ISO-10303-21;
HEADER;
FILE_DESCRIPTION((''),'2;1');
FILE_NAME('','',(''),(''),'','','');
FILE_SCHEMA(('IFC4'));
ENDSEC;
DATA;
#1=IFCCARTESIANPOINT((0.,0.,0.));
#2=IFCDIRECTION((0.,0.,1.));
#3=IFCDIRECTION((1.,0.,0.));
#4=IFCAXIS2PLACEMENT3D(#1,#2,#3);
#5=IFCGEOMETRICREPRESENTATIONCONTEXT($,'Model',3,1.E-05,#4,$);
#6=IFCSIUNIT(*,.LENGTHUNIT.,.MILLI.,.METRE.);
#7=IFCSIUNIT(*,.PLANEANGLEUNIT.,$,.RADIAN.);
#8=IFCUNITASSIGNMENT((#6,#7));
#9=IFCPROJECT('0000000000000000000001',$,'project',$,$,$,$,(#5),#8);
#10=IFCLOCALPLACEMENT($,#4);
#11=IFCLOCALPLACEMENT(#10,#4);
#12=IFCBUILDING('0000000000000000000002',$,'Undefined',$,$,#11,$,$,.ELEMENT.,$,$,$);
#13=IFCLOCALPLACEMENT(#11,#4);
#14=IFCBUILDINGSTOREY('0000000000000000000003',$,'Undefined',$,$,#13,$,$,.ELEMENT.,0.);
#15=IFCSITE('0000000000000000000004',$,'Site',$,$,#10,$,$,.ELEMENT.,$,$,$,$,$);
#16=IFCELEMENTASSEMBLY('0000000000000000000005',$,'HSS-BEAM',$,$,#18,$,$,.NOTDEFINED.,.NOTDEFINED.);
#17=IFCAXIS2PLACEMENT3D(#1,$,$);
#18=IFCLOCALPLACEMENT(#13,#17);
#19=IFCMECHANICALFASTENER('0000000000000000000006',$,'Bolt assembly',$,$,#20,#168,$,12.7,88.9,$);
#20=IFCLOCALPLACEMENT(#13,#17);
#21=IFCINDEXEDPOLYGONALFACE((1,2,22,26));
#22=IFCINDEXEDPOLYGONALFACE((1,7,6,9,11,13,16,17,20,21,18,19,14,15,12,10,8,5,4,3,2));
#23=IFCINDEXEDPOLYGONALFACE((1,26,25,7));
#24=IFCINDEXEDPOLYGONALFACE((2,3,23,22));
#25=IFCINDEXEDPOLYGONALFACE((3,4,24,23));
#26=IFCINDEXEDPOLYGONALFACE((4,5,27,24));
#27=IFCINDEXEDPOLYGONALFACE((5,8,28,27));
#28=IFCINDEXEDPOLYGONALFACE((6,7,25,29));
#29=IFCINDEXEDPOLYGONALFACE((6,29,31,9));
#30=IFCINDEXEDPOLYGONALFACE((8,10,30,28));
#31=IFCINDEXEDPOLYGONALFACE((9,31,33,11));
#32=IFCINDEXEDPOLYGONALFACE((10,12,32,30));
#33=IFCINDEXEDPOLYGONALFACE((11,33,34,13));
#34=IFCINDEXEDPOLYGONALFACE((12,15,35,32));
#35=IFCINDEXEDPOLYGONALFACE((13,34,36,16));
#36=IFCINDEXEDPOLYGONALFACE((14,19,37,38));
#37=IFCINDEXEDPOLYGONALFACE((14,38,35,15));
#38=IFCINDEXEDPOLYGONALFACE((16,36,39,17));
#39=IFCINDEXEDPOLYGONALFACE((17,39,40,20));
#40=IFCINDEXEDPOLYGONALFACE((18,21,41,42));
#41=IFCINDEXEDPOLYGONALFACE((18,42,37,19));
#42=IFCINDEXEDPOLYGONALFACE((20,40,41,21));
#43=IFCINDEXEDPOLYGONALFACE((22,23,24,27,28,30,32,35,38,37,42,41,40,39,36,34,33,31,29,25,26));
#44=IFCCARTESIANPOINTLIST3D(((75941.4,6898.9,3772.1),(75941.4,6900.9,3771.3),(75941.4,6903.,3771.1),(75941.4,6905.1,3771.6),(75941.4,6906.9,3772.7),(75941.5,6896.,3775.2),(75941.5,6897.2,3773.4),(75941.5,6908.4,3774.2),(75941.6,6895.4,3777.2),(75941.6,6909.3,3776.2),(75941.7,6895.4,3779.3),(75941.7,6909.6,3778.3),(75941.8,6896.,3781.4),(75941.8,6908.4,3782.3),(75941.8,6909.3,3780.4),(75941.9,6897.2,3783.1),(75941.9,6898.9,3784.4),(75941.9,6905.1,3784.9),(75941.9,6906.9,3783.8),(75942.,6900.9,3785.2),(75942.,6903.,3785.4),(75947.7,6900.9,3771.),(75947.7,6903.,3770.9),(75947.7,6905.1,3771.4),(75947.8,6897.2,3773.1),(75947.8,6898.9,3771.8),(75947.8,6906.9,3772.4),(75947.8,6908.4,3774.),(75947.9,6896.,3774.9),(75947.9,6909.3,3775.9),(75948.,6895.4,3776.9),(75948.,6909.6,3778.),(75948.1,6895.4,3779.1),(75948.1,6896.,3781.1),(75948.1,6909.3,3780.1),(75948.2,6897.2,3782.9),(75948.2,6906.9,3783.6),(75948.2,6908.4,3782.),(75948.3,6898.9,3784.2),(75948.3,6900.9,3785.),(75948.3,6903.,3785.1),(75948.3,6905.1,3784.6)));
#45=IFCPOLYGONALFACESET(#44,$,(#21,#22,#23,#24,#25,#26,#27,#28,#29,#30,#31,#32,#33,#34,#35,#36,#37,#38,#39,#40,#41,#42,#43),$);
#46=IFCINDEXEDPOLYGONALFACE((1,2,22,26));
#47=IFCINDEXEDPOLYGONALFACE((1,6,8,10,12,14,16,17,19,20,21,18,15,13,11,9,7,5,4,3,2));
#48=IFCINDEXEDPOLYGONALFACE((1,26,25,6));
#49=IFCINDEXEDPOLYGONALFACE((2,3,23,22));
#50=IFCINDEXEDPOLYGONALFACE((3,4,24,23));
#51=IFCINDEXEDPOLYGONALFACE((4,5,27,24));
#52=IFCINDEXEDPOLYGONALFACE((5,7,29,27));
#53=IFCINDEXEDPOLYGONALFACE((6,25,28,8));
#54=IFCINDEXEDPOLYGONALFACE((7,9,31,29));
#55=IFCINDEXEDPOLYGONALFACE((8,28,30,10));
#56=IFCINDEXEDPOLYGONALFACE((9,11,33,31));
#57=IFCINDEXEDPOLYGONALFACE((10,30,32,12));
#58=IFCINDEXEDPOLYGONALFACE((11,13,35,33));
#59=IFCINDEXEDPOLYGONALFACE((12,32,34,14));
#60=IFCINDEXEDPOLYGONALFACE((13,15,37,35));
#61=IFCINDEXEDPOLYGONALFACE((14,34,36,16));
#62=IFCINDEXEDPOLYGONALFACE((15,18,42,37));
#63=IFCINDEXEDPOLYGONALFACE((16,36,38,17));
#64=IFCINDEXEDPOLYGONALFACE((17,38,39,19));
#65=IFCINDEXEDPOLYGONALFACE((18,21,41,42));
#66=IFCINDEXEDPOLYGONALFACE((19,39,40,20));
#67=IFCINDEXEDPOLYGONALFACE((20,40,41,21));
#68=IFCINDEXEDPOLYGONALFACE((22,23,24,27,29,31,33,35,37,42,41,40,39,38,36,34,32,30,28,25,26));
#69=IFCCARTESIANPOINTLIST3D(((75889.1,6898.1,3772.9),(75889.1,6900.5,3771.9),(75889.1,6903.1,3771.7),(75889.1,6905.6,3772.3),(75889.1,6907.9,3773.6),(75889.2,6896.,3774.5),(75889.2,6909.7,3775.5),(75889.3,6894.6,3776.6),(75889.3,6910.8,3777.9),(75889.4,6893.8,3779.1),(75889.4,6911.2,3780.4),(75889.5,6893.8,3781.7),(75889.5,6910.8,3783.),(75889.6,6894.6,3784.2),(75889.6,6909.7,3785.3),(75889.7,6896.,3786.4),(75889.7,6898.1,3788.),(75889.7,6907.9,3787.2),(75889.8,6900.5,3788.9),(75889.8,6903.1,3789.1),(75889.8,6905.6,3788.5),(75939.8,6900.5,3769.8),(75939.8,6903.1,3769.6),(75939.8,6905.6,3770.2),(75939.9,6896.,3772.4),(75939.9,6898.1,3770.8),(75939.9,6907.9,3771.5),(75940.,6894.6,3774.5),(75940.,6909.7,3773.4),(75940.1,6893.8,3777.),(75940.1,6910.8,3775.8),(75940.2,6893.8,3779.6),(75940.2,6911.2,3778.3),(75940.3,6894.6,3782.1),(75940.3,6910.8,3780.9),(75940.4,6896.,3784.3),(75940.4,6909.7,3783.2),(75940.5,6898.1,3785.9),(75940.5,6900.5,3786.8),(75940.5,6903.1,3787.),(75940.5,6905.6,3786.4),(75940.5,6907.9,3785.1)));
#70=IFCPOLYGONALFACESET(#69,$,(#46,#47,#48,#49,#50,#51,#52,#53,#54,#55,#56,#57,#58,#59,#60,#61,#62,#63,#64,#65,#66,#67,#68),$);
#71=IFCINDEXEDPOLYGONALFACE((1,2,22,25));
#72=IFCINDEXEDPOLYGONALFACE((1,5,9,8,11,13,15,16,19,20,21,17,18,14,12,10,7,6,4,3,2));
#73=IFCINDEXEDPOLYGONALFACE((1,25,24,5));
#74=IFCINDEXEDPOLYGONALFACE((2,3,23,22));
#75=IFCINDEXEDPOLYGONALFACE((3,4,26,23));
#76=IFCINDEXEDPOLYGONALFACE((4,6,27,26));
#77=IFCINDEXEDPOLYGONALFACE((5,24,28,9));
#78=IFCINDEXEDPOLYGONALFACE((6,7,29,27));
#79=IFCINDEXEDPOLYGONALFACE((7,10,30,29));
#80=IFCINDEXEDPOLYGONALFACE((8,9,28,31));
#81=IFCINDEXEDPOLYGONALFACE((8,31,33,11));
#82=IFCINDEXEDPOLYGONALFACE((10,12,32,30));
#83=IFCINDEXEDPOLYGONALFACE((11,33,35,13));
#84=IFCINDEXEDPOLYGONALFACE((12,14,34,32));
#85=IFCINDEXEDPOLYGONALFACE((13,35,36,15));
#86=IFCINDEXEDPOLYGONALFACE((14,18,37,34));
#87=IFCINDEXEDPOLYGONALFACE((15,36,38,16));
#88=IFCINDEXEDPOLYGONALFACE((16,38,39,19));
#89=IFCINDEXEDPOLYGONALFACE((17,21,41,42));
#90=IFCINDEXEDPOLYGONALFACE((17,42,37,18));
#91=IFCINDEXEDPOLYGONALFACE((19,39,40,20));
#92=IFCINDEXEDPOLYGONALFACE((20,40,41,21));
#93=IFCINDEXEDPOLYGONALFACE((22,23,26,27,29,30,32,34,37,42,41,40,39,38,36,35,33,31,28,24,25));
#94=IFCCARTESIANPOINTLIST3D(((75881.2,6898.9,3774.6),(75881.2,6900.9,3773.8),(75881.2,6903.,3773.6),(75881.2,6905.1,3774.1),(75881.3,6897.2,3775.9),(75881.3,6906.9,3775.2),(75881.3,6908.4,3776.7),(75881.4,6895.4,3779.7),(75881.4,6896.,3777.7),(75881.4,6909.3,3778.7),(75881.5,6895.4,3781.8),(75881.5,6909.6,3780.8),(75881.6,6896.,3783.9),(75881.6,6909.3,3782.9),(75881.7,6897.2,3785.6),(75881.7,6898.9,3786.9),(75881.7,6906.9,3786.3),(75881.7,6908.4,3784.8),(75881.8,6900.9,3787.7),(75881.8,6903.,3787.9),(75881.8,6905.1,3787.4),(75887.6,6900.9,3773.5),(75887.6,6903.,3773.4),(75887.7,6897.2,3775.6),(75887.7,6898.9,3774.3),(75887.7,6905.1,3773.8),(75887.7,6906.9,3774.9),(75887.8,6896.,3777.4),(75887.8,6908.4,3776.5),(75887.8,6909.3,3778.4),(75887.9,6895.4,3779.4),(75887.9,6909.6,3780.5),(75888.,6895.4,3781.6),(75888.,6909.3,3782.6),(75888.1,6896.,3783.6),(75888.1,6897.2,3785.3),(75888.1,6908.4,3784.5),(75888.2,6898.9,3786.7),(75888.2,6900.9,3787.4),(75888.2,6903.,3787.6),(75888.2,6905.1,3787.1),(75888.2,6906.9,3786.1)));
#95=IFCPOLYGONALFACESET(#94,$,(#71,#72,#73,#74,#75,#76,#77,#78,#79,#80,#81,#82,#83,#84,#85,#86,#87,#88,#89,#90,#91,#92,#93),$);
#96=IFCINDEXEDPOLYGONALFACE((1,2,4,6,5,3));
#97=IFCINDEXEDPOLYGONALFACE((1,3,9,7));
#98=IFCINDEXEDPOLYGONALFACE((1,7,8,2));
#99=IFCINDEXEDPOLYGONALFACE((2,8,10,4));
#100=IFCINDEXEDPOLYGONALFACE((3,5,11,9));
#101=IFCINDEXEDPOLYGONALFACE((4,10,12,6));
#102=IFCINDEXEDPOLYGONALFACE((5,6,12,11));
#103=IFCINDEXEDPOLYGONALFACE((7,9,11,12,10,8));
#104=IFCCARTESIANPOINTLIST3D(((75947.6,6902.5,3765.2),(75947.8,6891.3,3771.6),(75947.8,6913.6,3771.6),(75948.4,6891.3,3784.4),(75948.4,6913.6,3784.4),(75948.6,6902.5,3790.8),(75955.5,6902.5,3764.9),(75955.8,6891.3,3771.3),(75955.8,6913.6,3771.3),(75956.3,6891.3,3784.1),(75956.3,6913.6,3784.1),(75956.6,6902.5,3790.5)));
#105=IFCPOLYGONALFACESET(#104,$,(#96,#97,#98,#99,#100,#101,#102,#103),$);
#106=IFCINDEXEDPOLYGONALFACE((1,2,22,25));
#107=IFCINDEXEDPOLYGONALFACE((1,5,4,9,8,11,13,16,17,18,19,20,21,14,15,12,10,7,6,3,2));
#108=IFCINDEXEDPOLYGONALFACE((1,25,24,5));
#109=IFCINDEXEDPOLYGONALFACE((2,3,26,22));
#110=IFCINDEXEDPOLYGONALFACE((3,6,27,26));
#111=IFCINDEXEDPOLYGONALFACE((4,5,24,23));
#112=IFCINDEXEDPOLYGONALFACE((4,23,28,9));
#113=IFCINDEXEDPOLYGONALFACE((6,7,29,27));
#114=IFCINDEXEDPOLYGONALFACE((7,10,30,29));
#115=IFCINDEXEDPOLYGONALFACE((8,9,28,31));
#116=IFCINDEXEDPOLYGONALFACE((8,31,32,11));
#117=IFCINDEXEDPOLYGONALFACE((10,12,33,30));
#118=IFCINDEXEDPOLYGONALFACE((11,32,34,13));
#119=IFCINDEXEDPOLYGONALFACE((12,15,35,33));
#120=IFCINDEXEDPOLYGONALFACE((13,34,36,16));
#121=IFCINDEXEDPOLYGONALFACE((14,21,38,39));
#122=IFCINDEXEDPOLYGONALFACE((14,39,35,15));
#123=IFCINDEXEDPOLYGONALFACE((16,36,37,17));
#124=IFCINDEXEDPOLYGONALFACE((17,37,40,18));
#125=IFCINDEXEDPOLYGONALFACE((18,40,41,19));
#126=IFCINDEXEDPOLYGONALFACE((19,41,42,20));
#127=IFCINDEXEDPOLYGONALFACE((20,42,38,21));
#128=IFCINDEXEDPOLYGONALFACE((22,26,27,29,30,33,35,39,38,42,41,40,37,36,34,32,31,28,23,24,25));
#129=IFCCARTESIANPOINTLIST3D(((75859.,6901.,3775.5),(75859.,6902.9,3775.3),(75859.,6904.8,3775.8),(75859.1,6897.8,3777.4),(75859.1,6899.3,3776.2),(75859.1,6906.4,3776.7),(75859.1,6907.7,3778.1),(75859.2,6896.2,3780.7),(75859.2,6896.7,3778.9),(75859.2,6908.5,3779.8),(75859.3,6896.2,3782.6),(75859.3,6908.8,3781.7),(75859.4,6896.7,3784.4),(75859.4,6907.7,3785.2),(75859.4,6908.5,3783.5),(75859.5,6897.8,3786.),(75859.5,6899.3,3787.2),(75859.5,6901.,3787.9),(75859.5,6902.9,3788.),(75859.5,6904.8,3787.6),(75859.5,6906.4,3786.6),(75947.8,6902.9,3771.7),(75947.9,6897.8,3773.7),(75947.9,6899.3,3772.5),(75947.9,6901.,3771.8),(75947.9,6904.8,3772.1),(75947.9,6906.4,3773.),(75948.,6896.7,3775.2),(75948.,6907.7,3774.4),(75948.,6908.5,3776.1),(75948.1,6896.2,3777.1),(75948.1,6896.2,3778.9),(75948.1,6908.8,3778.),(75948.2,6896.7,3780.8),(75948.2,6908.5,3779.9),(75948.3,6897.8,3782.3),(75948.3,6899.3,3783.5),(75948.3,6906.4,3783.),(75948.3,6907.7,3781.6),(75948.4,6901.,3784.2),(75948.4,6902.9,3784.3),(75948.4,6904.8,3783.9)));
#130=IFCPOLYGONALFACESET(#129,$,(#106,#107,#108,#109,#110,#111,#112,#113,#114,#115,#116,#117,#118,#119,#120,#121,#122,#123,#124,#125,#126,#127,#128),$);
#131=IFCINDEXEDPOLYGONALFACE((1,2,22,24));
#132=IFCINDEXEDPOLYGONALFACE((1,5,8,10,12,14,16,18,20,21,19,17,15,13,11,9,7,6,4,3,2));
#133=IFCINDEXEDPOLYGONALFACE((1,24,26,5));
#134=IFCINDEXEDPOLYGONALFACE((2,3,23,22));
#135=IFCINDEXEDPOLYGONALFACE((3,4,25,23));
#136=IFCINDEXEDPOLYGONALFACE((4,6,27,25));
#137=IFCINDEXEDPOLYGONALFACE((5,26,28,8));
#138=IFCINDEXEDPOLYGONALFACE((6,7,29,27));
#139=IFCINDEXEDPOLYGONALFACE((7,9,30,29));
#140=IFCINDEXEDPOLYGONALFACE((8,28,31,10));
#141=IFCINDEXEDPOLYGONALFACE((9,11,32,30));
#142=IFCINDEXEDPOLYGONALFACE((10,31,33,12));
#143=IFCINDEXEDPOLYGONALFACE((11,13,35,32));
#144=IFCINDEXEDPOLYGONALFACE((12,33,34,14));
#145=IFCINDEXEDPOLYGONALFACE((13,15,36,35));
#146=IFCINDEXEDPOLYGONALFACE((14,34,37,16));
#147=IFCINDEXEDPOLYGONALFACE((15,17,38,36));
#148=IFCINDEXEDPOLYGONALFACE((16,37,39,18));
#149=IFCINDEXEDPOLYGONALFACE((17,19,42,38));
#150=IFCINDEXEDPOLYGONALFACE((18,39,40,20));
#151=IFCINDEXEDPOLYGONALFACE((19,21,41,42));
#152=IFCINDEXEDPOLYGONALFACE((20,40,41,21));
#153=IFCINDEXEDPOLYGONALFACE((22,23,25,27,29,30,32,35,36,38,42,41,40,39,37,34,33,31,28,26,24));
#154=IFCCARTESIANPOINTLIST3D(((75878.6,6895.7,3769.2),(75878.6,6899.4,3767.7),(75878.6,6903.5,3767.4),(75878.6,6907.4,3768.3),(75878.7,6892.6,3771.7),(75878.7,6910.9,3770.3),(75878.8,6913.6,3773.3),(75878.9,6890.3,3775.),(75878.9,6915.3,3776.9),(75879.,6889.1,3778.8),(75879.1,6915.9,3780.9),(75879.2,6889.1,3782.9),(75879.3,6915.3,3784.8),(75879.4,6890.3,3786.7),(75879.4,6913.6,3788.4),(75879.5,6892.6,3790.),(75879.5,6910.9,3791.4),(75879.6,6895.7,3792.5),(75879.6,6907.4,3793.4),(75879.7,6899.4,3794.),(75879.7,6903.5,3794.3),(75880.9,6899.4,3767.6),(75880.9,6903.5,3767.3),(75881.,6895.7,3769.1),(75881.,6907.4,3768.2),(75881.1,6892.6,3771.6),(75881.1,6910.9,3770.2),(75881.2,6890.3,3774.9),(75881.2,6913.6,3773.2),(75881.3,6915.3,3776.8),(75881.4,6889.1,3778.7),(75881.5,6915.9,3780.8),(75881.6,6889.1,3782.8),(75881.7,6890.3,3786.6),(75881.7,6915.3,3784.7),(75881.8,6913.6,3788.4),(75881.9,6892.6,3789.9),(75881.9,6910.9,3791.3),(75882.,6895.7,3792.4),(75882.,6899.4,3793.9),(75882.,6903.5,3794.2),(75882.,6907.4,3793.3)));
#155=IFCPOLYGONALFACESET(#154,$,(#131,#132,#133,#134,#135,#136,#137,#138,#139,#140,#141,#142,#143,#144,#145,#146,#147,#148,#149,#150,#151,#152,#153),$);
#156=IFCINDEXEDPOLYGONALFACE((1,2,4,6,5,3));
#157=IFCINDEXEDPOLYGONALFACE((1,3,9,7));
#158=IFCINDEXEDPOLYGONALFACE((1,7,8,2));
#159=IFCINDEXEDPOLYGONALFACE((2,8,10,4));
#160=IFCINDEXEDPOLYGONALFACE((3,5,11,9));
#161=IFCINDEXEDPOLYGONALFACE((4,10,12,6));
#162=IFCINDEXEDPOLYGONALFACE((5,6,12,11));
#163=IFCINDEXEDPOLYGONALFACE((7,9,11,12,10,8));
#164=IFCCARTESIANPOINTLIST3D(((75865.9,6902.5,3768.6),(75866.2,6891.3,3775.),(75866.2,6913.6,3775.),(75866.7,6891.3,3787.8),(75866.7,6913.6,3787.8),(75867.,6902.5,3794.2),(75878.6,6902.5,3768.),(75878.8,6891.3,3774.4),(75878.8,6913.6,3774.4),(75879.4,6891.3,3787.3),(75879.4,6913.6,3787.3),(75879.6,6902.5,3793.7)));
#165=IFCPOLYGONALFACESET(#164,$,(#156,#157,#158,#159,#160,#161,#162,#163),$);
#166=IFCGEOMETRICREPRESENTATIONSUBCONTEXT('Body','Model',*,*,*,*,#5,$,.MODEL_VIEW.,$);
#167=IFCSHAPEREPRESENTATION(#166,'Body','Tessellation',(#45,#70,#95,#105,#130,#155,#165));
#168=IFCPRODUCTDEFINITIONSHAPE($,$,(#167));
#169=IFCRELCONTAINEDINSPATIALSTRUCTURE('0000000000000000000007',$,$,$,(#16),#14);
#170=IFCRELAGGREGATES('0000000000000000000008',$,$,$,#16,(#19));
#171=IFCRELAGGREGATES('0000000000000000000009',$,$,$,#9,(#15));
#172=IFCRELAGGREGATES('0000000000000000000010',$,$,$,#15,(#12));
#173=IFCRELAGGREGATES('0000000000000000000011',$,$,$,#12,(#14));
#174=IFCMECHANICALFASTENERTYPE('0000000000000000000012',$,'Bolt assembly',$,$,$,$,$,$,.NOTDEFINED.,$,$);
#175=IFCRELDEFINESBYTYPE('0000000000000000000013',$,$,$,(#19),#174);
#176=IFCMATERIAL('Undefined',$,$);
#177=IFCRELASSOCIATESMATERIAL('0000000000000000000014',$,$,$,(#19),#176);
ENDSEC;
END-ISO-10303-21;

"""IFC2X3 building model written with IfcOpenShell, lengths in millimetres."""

from ifc_helpers import new_model, si_unit, frame, origin_with_axes, origin_2d_with_axis, place, context, subcontext, project, spatial, polyline, circle, outline, extrude, source, transform, mapped, material, type_object, element, aggregate, save


model = new_model("IFC2X3")

# Units and contexts
model_context = context("Model", 3, precision=1e-05, world=origin_with_axes())
body_context = subcontext(model_context, "Body", "Model", "MODEL_VIEW")
ifc_project = project(units=[si_unit("LENGTHUNIT", "METRE", prefix="MILLI"), si_unit("PLANEANGLEUNIT", "RADIAN")], contexts=[model_context])

# Site, building, storey
site_placement = place(None, origin_with_axes())
site = spatial("IfcSite", under=ifc_project, at=site_placement, Name="Site", CompositionType="ELEMENT")
building_placement = place(site_placement, origin_with_axes())
building = spatial("IfcBuilding", under=site, at=building_placement, Name="Undefined", CompositionType="ELEMENT")
storey_placement = place(building_placement, origin_with_axes())
storey = spatial("IfcBuildingStorey", under=building, at=storey_placement, Name="Undefined", CompositionType="ELEMENT", Elevation=0.0)

# Shared definitions
ifc_material_1 = material(Name="Undefined")
mechanical_fastener_type = type_object("IfcMechanicalFastenerType", Name="Bolt assembly")

# Shared definitions
shared_shape_1 = source(origin_with_axes(), body_context, "Body", "SweptSolid", [
    extrude(circle(Radius=7.1, at=origin_2d_with_axis()), frame((0.0, -33.2, 0.0), z_axis=(0.0, 1.0, 0.0), x_axis=(1.0, 0.0, 0.0)), (0.0, 0.0, 1.0), 6.3),
    extrude(circle(Radius=8.7, at=origin_2d_with_axis()), frame((0.0, -25.4, 0.0), z_axis=(0.0, 1.0, 0.0), x_axis=(1.0, 0.0, 0.0)), (0.0, 0.0, 1.0), 50.8),
    extrude(circle(Radius=7.1, at=origin_2d_with_axis()), frame((0.0, 26.9, 0.0), z_axis=(0.0, 1.0, 0.0), x_axis=(1.0, 0.0, 0.0)), (0.0, 0.0, 1.0), 6.5),
    extrude(outline(polyline([(11.1, -6.4), (11.1, 6.4), (0.0, 12.8), (-11.1, 6.4), (-11.1, -6.4), (0.0, -12.8), (11.1, -6.4)])), frame((0.0, -41.3, 0.0), z_axis=(0.0, 1.0, 0.0), x_axis=(1.0, 0.0, 0.0)), (0.0, 0.0, 1.0), 7.9),
    extrude(circle(Radius=6.3, at=origin_2d_with_axis()), frame((0.0, -33.3, 0.0), z_axis=(0.0, 1.0, 0.0), x_axis=(1.0, 0.0, 0.0)), (0.0, 0.0, 1.0), 88.9),
    extrude(circle(Radius=13.5, at=origin_2d_with_axis()), frame((0.0, 33.3, 0.0), z_axis=(0.0, 1.0, 0.0), x_axis=(1.0, 0.0, 0.0)), (0.0, 0.0, 1.0), 2.4),
    extrude(outline(polyline([(11.1, -6.4), (11.1, 6.4), (0.0, 12.8), (-11.1, 6.4), (-11.1, -6.4), (0.0, -12.8), (11.1, -6.4)])), frame((0.0, 35.7, 0.0), z_axis=(0.0, 1.0, 0.0), x_axis=(1.0, 0.0, 0.0)), (0.0, 0.0, 1.0), 12.7),
])

# Element assembly, mechanical fastener
assembly_1_placement = place(storey_placement, origin_with_axes())
assembly_1 = element("IfcElementAssembly", 1, at=assembly_1_placement, inside=storey, Name="HSS-BEAM", AssemblyPlace="NOTDEFINED", PredefinedType="NOTDEFINED")
mechanical_fastener_1_placement = place(assembly_1_placement, frame((75914.8, 6902.5, 3779.4), z_axis=(0.041337, 0.0, 0.999145), x_axis=(0.0, 1.0, 0.0)))
mechanical_fastener_1 = element("IfcMechanicalFastener", 2, at=mechanical_fastener_1_placement, type_object=mechanical_fastener_type, material=ifc_material_1, Name="Bolt assembly", NominalDiameter=12.7, NominalLength=88.9, context=body_context, shape_type="MappedRepresentation", body=[
    mapped(shared_shape_1, transform((0.0, 0.0, 0.0))),
])
aggregate(assembly_1, [mechanical_fastener_1])

save(model, "model.ifc")
